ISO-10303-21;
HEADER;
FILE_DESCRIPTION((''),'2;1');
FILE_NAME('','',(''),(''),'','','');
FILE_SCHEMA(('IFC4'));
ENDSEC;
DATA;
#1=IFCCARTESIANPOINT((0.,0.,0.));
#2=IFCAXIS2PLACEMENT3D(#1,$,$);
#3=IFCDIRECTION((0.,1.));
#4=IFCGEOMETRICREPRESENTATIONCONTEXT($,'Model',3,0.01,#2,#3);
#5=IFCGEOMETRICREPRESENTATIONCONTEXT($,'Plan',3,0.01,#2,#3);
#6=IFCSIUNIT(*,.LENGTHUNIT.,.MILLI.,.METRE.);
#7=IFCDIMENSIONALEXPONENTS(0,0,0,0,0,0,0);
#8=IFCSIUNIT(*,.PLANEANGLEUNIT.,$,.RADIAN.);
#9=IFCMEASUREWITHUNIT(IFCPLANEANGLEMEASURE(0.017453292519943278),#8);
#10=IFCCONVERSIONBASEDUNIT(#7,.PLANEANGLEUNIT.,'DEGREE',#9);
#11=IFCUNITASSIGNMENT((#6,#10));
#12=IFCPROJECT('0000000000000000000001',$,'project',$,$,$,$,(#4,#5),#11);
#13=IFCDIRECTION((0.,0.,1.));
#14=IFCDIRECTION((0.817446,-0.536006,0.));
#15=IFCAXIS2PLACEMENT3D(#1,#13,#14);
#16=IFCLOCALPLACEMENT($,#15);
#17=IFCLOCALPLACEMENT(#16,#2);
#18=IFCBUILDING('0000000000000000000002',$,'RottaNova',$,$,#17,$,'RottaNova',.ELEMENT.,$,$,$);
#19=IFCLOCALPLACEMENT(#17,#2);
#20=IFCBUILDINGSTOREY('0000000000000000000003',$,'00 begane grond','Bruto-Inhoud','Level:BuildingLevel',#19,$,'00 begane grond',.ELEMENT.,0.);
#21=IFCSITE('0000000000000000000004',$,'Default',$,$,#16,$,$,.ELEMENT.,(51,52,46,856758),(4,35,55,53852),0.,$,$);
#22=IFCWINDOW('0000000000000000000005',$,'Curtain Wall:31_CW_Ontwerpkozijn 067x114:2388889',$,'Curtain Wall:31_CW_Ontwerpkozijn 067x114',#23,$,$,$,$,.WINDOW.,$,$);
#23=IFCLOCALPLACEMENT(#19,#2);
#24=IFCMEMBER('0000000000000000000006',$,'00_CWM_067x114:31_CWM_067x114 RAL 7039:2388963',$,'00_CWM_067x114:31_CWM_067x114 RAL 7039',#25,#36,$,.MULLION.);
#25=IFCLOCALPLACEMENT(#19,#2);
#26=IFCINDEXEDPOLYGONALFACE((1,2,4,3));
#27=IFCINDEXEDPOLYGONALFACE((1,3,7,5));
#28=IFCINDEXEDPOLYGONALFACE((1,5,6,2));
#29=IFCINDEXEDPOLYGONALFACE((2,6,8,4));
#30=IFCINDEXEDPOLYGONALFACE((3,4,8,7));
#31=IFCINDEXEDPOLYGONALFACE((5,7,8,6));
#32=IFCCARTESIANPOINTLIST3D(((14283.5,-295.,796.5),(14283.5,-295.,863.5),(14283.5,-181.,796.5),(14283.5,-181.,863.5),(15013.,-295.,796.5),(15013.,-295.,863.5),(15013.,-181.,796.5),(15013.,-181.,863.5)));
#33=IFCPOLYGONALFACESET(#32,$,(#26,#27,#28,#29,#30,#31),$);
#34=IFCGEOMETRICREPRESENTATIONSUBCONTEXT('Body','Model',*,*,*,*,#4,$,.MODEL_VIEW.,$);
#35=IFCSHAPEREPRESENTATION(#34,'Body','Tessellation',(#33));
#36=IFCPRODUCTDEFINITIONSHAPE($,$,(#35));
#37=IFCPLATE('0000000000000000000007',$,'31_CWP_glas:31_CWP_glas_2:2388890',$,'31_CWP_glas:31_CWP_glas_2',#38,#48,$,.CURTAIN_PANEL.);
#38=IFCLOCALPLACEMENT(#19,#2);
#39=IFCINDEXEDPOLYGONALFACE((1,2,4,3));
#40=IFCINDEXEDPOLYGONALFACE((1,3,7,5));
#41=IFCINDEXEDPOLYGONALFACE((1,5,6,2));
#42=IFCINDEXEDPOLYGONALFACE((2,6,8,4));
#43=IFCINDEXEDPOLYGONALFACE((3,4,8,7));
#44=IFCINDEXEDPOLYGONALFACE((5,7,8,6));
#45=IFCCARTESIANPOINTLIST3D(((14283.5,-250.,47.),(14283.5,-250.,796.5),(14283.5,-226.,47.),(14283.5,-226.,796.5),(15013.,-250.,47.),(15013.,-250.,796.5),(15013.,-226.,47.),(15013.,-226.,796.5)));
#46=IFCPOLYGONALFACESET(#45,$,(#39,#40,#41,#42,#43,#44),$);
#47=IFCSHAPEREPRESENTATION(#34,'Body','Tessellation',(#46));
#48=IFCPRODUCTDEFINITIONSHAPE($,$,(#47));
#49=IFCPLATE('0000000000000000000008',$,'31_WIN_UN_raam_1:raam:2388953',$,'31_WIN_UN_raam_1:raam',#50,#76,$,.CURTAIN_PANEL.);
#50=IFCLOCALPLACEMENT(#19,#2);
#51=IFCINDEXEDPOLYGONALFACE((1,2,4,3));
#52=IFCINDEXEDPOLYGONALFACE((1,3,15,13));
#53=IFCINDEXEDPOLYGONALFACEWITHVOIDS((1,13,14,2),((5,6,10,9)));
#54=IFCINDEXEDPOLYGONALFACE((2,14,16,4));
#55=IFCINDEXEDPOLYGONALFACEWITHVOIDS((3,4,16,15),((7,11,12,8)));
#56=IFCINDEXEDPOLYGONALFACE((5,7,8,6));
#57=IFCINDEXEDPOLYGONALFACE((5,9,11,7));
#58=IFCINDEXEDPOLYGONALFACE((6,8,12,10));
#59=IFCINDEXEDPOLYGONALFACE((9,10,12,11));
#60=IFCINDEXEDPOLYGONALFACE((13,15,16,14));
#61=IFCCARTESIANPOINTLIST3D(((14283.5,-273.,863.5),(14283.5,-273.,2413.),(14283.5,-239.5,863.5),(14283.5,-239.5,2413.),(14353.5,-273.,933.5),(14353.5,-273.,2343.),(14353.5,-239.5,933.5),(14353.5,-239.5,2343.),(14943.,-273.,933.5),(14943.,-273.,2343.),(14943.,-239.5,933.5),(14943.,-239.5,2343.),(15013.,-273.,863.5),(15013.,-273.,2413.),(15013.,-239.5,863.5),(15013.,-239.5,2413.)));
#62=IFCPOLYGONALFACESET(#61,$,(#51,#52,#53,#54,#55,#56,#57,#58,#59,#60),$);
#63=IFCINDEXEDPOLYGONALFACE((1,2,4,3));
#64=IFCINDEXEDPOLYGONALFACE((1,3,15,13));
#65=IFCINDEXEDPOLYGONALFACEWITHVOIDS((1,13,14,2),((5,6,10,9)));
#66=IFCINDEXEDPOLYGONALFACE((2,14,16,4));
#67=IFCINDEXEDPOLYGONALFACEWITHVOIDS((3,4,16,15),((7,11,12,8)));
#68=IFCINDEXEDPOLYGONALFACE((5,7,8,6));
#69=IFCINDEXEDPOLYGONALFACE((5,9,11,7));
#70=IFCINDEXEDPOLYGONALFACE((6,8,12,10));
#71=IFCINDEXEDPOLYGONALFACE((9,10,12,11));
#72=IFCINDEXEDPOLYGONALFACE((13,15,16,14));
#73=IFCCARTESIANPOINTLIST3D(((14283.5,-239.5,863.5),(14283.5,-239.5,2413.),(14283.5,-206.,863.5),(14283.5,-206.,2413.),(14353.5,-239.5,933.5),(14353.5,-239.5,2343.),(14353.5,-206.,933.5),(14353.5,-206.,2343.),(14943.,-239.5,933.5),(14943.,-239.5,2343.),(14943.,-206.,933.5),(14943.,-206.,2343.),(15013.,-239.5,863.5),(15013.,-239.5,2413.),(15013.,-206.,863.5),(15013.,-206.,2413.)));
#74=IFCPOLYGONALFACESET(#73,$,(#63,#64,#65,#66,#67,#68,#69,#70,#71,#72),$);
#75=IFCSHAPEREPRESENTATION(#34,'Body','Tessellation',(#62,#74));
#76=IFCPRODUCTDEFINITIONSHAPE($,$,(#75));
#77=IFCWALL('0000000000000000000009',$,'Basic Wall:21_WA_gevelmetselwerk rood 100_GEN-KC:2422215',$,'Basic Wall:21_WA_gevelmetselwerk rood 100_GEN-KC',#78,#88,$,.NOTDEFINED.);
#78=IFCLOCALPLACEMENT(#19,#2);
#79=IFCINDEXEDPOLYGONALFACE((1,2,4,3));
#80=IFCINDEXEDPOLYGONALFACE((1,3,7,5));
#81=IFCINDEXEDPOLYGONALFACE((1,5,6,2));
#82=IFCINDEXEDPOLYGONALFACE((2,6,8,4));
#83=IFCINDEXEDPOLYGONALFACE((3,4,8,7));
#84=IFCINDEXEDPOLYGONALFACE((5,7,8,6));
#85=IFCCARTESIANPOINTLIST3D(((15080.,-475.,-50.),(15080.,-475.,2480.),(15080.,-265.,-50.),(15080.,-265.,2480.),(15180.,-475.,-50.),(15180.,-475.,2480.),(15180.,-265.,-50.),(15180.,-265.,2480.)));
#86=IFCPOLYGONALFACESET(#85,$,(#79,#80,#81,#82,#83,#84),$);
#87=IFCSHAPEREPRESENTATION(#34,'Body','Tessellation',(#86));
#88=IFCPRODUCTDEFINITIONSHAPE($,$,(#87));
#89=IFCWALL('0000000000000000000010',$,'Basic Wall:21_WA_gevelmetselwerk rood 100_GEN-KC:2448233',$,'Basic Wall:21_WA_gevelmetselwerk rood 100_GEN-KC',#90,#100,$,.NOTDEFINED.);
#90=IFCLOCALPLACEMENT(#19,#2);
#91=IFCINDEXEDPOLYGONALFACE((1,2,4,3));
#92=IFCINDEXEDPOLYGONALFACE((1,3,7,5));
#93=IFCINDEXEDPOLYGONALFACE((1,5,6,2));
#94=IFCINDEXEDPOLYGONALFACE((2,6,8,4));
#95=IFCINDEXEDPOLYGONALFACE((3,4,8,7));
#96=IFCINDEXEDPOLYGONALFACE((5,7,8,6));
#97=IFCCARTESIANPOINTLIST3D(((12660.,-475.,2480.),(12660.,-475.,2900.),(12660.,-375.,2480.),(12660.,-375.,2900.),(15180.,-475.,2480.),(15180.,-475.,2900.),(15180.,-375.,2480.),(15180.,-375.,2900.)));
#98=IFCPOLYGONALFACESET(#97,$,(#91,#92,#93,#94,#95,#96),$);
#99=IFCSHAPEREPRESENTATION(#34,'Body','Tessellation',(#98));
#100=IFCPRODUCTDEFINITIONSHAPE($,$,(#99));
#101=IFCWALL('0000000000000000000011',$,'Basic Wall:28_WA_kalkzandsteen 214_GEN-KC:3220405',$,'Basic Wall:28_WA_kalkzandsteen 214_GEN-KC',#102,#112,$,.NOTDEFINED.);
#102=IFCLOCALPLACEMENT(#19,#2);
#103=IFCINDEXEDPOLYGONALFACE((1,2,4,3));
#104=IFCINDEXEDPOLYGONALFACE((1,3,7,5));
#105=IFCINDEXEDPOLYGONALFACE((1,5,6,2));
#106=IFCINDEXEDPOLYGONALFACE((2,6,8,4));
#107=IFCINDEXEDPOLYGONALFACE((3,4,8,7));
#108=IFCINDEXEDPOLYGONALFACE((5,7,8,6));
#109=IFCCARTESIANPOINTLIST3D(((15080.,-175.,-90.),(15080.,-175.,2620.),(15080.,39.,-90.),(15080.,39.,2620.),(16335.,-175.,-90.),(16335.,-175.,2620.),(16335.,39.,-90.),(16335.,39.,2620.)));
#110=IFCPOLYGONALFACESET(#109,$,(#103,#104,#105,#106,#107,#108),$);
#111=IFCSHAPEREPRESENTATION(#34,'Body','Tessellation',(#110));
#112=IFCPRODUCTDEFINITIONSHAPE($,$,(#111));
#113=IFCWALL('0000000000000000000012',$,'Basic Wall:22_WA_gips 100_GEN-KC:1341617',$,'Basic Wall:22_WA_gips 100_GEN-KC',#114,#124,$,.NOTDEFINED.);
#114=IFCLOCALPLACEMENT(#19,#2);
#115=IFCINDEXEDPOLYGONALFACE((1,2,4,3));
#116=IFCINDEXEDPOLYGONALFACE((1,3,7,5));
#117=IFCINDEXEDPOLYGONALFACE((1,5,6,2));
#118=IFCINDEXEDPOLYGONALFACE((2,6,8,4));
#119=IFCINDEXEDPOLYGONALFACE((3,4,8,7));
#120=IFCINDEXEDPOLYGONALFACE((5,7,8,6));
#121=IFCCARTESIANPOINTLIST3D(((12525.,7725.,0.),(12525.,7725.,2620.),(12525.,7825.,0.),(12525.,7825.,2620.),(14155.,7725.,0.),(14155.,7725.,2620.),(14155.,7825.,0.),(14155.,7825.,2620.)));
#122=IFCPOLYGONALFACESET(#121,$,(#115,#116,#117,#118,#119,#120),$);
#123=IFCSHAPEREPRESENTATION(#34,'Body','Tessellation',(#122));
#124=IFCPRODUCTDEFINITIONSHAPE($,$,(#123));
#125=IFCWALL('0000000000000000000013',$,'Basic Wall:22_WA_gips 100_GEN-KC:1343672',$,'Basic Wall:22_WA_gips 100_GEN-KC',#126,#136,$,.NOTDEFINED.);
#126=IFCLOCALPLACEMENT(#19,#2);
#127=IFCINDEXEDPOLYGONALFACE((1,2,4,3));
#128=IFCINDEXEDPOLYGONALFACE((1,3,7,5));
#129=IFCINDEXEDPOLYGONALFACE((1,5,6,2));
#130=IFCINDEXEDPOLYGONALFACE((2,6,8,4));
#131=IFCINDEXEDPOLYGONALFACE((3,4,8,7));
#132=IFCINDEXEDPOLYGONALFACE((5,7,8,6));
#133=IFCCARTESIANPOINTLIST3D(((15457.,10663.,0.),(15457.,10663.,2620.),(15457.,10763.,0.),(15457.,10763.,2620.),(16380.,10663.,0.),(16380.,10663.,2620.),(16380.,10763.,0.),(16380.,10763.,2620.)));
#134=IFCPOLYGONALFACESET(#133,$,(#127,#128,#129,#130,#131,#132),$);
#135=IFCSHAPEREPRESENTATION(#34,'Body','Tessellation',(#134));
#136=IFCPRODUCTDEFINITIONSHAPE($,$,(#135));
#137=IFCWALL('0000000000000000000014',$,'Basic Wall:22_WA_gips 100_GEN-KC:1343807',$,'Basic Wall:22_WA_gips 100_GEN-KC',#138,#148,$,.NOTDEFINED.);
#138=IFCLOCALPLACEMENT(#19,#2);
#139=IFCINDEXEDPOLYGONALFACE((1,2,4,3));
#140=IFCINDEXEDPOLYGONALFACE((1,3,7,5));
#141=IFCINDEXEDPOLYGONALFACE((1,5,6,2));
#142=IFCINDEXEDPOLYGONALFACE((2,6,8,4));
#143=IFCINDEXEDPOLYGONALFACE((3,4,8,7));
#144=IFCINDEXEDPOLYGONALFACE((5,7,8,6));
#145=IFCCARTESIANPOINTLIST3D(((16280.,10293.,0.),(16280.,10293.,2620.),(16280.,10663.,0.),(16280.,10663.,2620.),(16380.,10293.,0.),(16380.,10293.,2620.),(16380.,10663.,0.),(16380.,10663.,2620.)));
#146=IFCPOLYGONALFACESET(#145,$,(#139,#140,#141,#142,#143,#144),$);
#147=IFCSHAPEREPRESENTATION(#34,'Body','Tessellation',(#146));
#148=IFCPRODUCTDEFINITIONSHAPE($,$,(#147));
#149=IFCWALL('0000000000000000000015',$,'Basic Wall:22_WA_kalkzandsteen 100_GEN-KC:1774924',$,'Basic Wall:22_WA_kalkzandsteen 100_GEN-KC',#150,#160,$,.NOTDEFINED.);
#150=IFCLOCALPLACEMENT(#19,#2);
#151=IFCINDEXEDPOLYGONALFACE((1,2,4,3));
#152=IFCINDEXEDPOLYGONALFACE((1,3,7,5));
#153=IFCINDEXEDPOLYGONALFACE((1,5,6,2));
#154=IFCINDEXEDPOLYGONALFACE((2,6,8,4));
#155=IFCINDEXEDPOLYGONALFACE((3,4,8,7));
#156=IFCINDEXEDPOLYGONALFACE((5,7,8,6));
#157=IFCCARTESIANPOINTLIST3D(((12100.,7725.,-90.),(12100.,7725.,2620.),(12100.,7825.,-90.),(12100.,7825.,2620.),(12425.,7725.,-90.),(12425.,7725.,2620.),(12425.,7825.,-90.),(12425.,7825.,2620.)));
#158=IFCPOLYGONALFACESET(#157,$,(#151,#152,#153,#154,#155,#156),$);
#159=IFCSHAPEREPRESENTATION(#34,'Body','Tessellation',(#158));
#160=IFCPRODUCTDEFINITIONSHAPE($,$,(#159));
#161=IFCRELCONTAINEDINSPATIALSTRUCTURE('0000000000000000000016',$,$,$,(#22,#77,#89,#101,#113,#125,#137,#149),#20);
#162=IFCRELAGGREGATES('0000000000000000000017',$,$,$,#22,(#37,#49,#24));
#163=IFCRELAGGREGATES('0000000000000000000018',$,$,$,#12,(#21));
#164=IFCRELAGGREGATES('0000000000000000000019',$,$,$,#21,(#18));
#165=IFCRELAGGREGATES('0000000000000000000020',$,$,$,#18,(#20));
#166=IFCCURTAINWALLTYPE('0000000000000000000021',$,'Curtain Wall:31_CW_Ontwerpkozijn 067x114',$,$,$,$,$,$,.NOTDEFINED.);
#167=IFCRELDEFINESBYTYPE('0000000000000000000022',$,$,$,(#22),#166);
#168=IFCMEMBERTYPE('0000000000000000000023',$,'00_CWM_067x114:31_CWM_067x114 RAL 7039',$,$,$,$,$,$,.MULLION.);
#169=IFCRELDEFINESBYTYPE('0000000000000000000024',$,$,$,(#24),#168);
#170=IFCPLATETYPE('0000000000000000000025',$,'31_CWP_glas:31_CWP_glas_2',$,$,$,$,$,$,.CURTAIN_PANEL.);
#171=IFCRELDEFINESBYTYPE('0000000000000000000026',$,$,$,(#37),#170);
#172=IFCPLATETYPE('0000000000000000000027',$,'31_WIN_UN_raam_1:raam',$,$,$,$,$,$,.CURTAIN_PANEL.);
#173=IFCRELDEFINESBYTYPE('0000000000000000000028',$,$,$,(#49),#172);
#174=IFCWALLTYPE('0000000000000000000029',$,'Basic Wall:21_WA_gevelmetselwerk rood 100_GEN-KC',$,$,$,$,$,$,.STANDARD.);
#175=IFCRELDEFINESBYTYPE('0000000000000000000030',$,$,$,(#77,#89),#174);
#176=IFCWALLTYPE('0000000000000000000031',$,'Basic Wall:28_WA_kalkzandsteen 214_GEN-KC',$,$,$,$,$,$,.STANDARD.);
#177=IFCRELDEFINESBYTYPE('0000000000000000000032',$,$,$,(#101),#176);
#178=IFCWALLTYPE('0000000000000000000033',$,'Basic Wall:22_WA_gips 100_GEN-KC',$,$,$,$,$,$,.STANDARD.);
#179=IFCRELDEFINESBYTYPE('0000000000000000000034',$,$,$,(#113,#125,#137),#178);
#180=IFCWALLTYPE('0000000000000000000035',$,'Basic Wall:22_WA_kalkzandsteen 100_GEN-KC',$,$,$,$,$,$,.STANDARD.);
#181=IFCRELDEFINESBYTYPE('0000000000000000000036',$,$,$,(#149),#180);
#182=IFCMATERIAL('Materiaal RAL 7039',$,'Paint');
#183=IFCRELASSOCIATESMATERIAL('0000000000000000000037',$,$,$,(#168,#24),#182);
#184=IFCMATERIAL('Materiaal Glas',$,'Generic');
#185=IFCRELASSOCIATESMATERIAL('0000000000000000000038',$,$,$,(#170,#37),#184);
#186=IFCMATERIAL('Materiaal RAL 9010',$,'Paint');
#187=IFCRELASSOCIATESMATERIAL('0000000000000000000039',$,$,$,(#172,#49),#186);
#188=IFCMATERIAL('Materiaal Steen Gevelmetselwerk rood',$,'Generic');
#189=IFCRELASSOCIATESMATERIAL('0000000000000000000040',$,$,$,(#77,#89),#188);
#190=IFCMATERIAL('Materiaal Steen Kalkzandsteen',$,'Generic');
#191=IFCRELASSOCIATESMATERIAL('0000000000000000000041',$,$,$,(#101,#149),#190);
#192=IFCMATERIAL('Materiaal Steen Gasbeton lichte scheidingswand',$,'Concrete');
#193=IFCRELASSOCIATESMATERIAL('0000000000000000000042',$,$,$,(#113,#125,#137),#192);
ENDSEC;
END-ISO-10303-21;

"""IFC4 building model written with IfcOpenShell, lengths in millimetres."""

from ifc_helpers import new_model, entity, si_unit, converted_unit, direction, frame, origin, place, context, subcontext, project, spatial, indexed_curve, outline, extrude, source, transform, mapped, material, type_object, type_shapes, element, aggregate, save


model = new_model("IFC4")

# Units and contexts
model_context = context("Model", 3, precision=0.01, world=origin(), true_north=direction((0.0, 1.0)))
plan_context = context("Plan", 3, precision=0.01, world=origin(), true_north=direction((0.0, 1.0)))
body_context = subcontext(model_context, "Body", "Model", "MODEL_VIEW")
ifc_project = project(units=[si_unit("LENGTHUNIT", "METRE", prefix="MILLI"), converted_unit("PLANEANGLEUNIT", "DEGREE", entity("IfcPlaneAngleMeasure", 0.017453292519943278), si_unit("PLANEANGLEUNIT", "RADIAN"), dimensions=[0, 0, 0, 0, 0, 0, 0])], contexts=[model_context, plan_context])

# Site, building, storey
site_placement = place(None, frame((0.0, 0.0, 0.0), z_axis=(0.0, 0.0, 1.0), x_axis=(0.817446, -0.536006, 0.0)))
site = spatial("IfcSite", under=ifc_project, at=site_placement, Name="Default", CompositionType="ELEMENT", RefLatitude=(51, 52, 46, 856758), RefLongitude=(4, 35, 55, 53852), RefElevation=0.0)
building_placement = place(site_placement, origin())
building = spatial("IfcBuilding", under=site, at=building_placement, Name="RottaNova", LongName="RottaNova", CompositionType="ELEMENT")
storey_placement = place(building_placement, origin())
storey = spatial("IfcBuildingStorey", under=building, at=storey_placement, Name="00 begane grond", Description="Bruto-Inhoud", ObjectType="Level:BuildingLevel", LongName="00 begane grond", CompositionType="ELEMENT", Elevation=0.0)

# Shared definitions
curtain_wall_type = type_object("IfcCurtainWallType", Name="Curtain Wall:31_CW_Ontwerpkozijn 067x114", PredefinedType="NOTDEFINED")
ifc_material_1 = material(Name="Materiaal RAL 7039", Category="Paint")

# Window
window_1_placement = place(storey_placement, origin())
window_1 = element("IfcWindow", 1, at=window_1_placement, inside=storey, type_object=curtain_wall_type, Name="Curtain Wall:31_CW_Ontwerpkozijn 067x114:2388889", ObjectType="Curtain Wall:31_CW_Ontwerpkozijn 067x114", PredefinedType="WINDOW")

# Member
member_type_1 = type_object("IfcMemberType", Name="00_CWM_067x114:31_CWM_067x114 RAL 7039", PredefinedType="MULLION", material=ifc_material_1)
shared_shape_1 = source(origin(), body_context, "Body", "SweptSolid", [
    extrude(outline(indexed_curve([(-33.5, -57.0), (33.5, -57.0), (33.5, 57.0), (-33.5, 57.0), (-33.5, -57.0)], self_intersect=False)), frame((0.0, -57.0, -729.5), z_axis=(0.0, 0.0, 1.0), x_axis=(-1.0, 0.0, 0.0)), (0.0, 0.0, 1.0), 729.5),
])
type_shapes(member_type_1, [shared_shape_1])
member_1_placement = place(window_1_placement, frame((14283.5, -181.0, 830.0), z_axis=(-1.0, 0.0, 0.0), x_axis=(0.0, 0.0, 1.0)))
member_1 = element("IfcMember", 2, at=member_1_placement, type_object=member_type_1, material=ifc_material_1, Name="00_CWM_067x114:31_CWM_067x114 RAL 7039:2388963", ObjectType="00_CWM_067x114:31_CWM_067x114 RAL 7039", PredefinedType="MULLION", context=body_context, shape_type="MappedRepresentation", body=[
    mapped(shared_shape_1, transform((0.0, 0.0, 0.0), scale=1.0)),
])

# Plates
ifc_material_2 = material(Name="Materiaal Glas", Category="Generic")
plate_type_1 = type_object("IfcPlateType", Name="31_CWP_glas:31_CWP_glas_2", PredefinedType="CURTAIN_PANEL", material=ifc_material_2)
shared_shape_2 = source(origin(), body_context, "Body", "SweptSolid", [
    extrude(outline(indexed_curve([(-12.0, -364.7), (12.0, -364.7), (12.0, 364.7), (-12.0, 364.7), (-12.0, -364.7)], self_intersect=False)), frame((0.0, 57.0, 0.0), z_axis=(0.0, 0.0, 1.0), x_axis=(0.0, 1.0, 0.0)), (0.0, 0.0, 1.0), 749.5),
])
type_shapes(plate_type_1, [shared_shape_2])
plate_1_placement = place(window_1_placement, frame((14648.3, -181.0, 47.0), z_axis=(0.0, 0.0, 1.0), x_axis=(-1.0, 0.0, 0.0)))
plate_1 = element("IfcPlate", 3, at=plate_1_placement, type_object=plate_type_1, material=ifc_material_2, Name="31_CWP_glas:31_CWP_glas_2:2388890", ObjectType="31_CWP_glas:31_CWP_glas_2", PredefinedType="CURTAIN_PANEL", context=body_context, shape_type="MappedRepresentation", body=[
    mapped(shared_shape_2, transform((0.0, 0.0, 0.0), scale=1.0)),
])
ifc_material_3 = material(Name="Materiaal RAL 9010", Category="Paint")
plate_type_2 = type_object("IfcPlateType", Name="31_WIN_UN_raam_1:raam", PredefinedType="CURTAIN_PANEL", material=ifc_material_3)
shared_shape_3 = source(origin(), body_context, "Body", "SweptSolid", [
    extrude(outline(indexed_curve([(-364.7, -774.7), (364.7, -774.7), (364.7, 774.7), (-364.7, 774.7), (-364.7, -774.7)], self_intersect=False), holes=[indexed_curve([(-294.7, 704.7), (294.7, 704.7), (294.7, -704.8), (-294.7, -704.8), (-294.7, 704.7)], self_intersect=False)]), frame((0.0, 58.5, 774.8), z_axis=(0.0, 1.0, 0.0), x_axis=(1.0, 0.0, 0.0)), (0.0, 0.0, 1.0), 33.5),
    extrude(outline(indexed_curve([(-364.7, -774.7), (364.7, -774.7), (364.7, 774.7), (-364.7, 774.7), (-364.7, -774.7)], self_intersect=False), holes=[indexed_curve([(-294.7, 704.7), (294.7, 704.7), (294.7, -704.8), (-294.7, -704.8), (-294.7, 704.7)], self_intersect=False)]), frame((0.0, 25.0, 774.8), z_axis=(0.0, 1.0, 0.0), x_axis=(1.0, 0.0, 0.0)), (0.0, 0.0, 1.0), 33.5),
])
type_shapes(plate_type_2, [shared_shape_3])
plate_2_placement = place(window_1_placement, frame((14648.3, -181.0, 863.5), z_axis=(0.0, 0.0, 1.0), x_axis=(-1.0, 0.0, 0.0)))
plate_2 = element("IfcPlate", 4, at=plate_2_placement, type_object=plate_type_2, material=ifc_material_3, Name="31_WIN_UN_raam_1:raam:2388953", ObjectType="31_WIN_UN_raam_1:raam", PredefinedType="CURTAIN_PANEL", context=body_context, shape_type="MappedRepresentation", body=[
    mapped(shared_shape_3, transform((0.0, 0.0, 0.0), scale=1.0)),
])
aggregate(window_1, [plate_1, plate_2, member_1])

# Walls
ifc_material_4 = material(Name="Materiaal Steen Gevelmetselwerk rood", Category="Generic")
wall_type_1 = type_object("IfcWallType", Name="Basic Wall:21_WA_gevelmetselwerk rood 100_GEN-KC", PredefinedType="STANDARD")
wall_1_placement = place(storey_placement, frame((15130.0, -265.0, -50.0), z_axis=(0.0, 0.0, 1.0), x_axis=(0.0, -1.0, 0.0)))
element("IfcWall", 5, at=wall_1_placement, inside=storey, type_object=wall_type_1, material=ifc_material_4, Name="Basic Wall:21_WA_gevelmetselwerk rood 100_GEN-KC:2422215", ObjectType="Basic Wall:21_WA_gevelmetselwerk rood 100_GEN-KC", PredefinedType="NOTDEFINED", context=body_context, shape_type="SweptSolid", body=[
    extrude(outline(indexed_curve([(210.0, 50.0), (0.0, 50.0), (0.0, -50.0), (210.0, -50.0), (210.0, 50.0)], self_intersect=False)), origin(), (0.0, 0.0, 1.0), 2530.0),
])
wall_2_placement = place(storey_placement, frame((15180.0, -425.0, 2480.0), z_axis=(0.0, 0.0, 1.0), x_axis=(-1.0, 0.0, 0.0)))
element("IfcWall", 6, at=wall_2_placement, inside=storey, type_object=wall_type_1, material=ifc_material_4, Name="Basic Wall:21_WA_gevelmetselwerk rood 100_GEN-KC:2448233", ObjectType="Basic Wall:21_WA_gevelmetselwerk rood 100_GEN-KC", PredefinedType="NOTDEFINED", context=body_context, shape_type="SweptSolid", body=[
    extrude(outline(indexed_curve([(2520.0, 50.0), (0.0, 50.0), (0.0, -50.0), (2520.0, -50.0), (2520.0, 50.0)], self_intersect=False)), origin(), (0.0, 0.0, 1.0), 420.0),
])
ifc_material_5 = material(Name="Materiaal Steen Kalkzandsteen", Category="Generic")
wall_type_2 = type_object("IfcWallType", Name="Basic Wall:28_WA_kalkzandsteen 214_GEN-KC", PredefinedType="STANDARD")
wall_3_placement = place(storey_placement, frame((16335.0, -68.0, -90.0), z_axis=(0.0, 0.0, 1.0), x_axis=(-1.0, 0.0, 0.0)))
element("IfcWall", 7, at=wall_3_placement, inside=storey, type_object=wall_type_2, material=ifc_material_5, Name="Basic Wall:28_WA_kalkzandsteen 214_GEN-KC:3220405", ObjectType="Basic Wall:28_WA_kalkzandsteen 214_GEN-KC", PredefinedType="NOTDEFINED", context=body_context, shape_type="SweptSolid", body=[
    extrude(outline(indexed_curve([(1255.0, 107.0), (0.0, 107.0), (0.0, -107.0), (1255.0, -107.0), (1255.0, 107.0)], self_intersect=False)), origin(), (0.0, 0.0, 1.0), 2710.0),
])
ifc_material_6 = material(Name="Materiaal Steen Gasbeton lichte scheidingswand", Category="Concrete")
wall_type_3 = type_object("IfcWallType", Name="Basic Wall:22_WA_gips 100_GEN-KC", PredefinedType="STANDARD")
wall_4_placement = place(storey_placement, frame((14155.0, 7775.0, 0.0), z_axis=(0.0, 0.0, 1.0), x_axis=(-1.0, 0.0, 0.0)))
element("IfcWall", 8, at=wall_4_placement, inside=storey, type_object=wall_type_3, material=ifc_material_6, Name="Basic Wall:22_WA_gips 100_GEN-KC:1341617", ObjectType="Basic Wall:22_WA_gips 100_GEN-KC", PredefinedType="NOTDEFINED", context=body_context, shape_type="SweptSolid", body=[
    extrude(outline(indexed_curve([(1630.0, 50.0), (0.0, 50.0), (0.0, -50.0), (1630.0, -50.0), (1630.0, 50.0)], self_intersect=False)), origin(), (0.0, 0.0, 1.0), 2620.0),
])
wall_5_placement = place(storey_placement, frame((16380.0, 10713.0, 0.0), z_axis=(0.0, 0.0, 1.0), x_axis=(-1.0, 0.0, 0.0)))
element("IfcWall", 9, at=wall_5_placement, inside=storey, type_object=wall_type_3, material=ifc_material_6, Name="Basic Wall:22_WA_gips 100_GEN-KC:1343672", ObjectType="Basic Wall:22_WA_gips 100_GEN-KC", PredefinedType="NOTDEFINED", context=body_context, shape_type="SweptSolid", body=[
    extrude(outline(indexed_curve([(923.0, 50.0), (0.0, 50.0), (0.0, -50.0), (923.0, -50.0), (923.0, 50.0)], self_intersect=False)), origin(), (0.0, 0.0, 1.0), 2620.0),
])
wall_6_placement = place(storey_placement, frame((16330.0, 10663.0, 0.0), z_axis=(0.0, 0.0, 1.0), x_axis=(0.0, -1.0, 0.0)))
element("IfcWall", 10, at=wall_6_placement, inside=storey, type_object=wall_type_3, material=ifc_material_6, Name="Basic Wall:22_WA_gips 100_GEN-KC:1343807", ObjectType="Basic Wall:22_WA_gips 100_GEN-KC", PredefinedType="NOTDEFINED", context=body_context, shape_type="SweptSolid", body=[
    extrude(outline(indexed_curve([(370.0, 50.0), (0.0, 50.0), (0.0, -50.0), (370.0, -50.0), (370.0, 50.0)], self_intersect=False)), origin(), (0.0, 0.0, 1.0), 2620.0),
])
wall_type_4 = type_object("IfcWallType", Name="Basic Wall:22_WA_kalkzandsteen 100_GEN-KC", PredefinedType="STANDARD")
wall_7_placement = place(storey_placement, frame((12100.0, 7775.0, -90.0)))
element("IfcWall", 11, at=wall_7_placement, inside=storey, type_object=wall_type_4, material=ifc_material_5, Name="Basic Wall:22_WA_kalkzandsteen 100_GEN-KC:1774924", ObjectType="Basic Wall:22_WA_kalkzandsteen 100_GEN-KC", PredefinedType="NOTDEFINED", context=body_context, shape_type="SweptSolid", body=[
    extrude(outline(indexed_curve([(325.0, 50.0), (0.0, 50.0), (0.0, -50.0), (325.0, -50.0), (325.0, 50.0)], self_intersect=False)), origin(), (0.0, 0.0, 1.0), 2710.0),
])

save(model, "model.ifc")
